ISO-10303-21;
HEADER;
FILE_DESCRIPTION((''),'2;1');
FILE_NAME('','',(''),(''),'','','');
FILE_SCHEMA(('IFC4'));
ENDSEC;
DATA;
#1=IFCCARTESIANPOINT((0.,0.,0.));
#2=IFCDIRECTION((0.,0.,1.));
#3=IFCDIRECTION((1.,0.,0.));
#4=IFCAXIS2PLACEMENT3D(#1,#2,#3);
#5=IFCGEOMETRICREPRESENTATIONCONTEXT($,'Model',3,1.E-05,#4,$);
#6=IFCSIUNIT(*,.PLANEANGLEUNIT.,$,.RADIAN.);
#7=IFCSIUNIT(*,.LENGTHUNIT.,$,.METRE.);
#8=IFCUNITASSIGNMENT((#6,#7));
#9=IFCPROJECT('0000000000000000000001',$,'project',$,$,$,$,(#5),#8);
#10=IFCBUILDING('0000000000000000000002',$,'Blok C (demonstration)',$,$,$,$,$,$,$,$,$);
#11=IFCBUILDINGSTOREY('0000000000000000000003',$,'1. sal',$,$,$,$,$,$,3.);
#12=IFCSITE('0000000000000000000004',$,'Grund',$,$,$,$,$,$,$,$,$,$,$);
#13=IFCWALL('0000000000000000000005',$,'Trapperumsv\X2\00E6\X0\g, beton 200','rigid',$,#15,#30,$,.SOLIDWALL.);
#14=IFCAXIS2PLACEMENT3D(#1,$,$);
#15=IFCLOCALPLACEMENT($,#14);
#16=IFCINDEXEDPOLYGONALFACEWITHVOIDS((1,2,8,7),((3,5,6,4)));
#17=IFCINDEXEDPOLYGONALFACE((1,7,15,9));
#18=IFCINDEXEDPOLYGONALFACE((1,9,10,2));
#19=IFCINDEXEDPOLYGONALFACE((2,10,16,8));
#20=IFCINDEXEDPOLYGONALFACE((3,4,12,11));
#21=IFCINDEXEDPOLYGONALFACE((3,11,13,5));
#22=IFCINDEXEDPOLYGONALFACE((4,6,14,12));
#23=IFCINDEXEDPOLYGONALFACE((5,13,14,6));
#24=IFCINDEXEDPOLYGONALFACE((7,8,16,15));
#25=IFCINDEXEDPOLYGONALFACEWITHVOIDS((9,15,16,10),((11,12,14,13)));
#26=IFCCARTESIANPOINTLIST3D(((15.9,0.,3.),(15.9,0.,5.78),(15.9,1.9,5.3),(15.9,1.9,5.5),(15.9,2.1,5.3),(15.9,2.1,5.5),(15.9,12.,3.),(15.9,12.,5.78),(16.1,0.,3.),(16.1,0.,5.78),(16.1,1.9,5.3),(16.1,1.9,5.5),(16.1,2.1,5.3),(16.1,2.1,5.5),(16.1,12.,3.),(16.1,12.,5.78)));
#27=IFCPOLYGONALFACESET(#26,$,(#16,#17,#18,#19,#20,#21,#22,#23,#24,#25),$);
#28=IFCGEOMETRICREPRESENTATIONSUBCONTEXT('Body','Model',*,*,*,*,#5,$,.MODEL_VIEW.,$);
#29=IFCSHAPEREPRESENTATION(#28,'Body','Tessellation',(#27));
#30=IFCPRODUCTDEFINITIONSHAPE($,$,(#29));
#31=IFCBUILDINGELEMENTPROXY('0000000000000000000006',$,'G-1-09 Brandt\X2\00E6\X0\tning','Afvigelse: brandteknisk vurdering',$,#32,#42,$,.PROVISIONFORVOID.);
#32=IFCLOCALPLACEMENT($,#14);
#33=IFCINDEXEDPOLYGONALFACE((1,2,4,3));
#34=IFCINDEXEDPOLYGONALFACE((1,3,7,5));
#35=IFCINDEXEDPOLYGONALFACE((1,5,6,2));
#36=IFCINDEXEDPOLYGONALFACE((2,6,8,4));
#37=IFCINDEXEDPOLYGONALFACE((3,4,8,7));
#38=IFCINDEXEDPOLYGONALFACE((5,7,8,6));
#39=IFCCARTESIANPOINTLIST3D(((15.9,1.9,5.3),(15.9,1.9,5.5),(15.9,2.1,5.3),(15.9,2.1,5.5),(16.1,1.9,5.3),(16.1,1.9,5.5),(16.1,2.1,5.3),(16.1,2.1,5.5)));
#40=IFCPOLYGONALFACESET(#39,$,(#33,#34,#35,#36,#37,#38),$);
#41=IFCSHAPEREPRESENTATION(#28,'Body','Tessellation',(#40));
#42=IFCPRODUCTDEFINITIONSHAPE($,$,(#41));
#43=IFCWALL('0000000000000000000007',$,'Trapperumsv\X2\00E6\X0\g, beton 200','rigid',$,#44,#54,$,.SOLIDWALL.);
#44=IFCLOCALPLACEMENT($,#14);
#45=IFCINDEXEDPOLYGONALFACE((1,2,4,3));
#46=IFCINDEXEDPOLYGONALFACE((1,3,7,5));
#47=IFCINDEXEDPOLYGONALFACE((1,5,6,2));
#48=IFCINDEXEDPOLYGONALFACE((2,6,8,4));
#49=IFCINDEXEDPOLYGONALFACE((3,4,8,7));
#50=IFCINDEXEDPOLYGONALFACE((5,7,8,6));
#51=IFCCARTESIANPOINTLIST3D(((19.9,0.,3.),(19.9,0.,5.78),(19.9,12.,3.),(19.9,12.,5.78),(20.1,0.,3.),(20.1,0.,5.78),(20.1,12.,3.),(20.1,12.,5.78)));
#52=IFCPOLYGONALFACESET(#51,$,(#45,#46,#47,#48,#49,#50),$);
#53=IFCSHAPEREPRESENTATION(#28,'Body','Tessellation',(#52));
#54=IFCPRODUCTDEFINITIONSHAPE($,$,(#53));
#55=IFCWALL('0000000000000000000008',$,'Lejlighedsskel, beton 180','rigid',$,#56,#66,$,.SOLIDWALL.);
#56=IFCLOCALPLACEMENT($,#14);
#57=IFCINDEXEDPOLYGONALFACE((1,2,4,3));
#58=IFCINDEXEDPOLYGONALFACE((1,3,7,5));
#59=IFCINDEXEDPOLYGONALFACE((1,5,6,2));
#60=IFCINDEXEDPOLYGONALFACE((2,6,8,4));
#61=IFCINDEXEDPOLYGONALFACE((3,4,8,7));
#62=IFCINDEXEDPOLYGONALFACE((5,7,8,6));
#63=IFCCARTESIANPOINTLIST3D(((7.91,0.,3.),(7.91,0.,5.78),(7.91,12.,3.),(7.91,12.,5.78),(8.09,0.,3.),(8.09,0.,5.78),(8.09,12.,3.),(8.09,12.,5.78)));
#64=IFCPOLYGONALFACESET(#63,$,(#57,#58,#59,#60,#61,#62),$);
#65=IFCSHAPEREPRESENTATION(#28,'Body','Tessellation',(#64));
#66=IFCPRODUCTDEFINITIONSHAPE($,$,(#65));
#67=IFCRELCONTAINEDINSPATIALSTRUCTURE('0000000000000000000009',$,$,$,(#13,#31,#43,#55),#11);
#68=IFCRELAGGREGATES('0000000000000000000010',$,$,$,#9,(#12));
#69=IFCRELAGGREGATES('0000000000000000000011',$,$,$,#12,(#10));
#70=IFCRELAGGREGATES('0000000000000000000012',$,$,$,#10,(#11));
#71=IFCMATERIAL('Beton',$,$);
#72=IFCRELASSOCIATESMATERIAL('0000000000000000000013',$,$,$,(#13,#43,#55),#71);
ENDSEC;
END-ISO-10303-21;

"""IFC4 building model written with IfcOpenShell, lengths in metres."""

from ifc_helpers import new_model, si_unit, frame, origin_with_axes, place, context, subcontext, project, spatial, polyline, outline, extrude, material, element, fill, save


model = new_model("IFC4")

# Units and contexts
model_context = context("Model", 3, precision=1e-05, world=origin_with_axes())
body_context = subcontext(model_context, "Body", "Model", "MODEL_VIEW")
ifc_project = project(units=[si_unit("PLANEANGLEUNIT", "RADIAN"), si_unit("LENGTHUNIT", "METRE")], contexts=[model_context])

# Site, building, storey
site = spatial("IfcSite", under=ifc_project, Name="Grund")
building = spatial("IfcBuilding", under=site, Name="Blok C (demonstration)")
storey = spatial("IfcBuildingStorey", under=building, Name="1. sal", Elevation=3.0)

# Wall, opening, building element proxy
ifc_material_1 = material(Name="Beton")
wall_1_placement = place(None, origin_with_axes())
wall_1 = element("IfcWall", 1, at=wall_1_placement, inside=storey, material=ifc_material_1, Name="Trapperumsvæg, beton 200", Description="rigid", PredefinedType="SOLIDWALL", context=body_context, shape_type="SweptSolid", body=[
    extrude(outline(polyline([(15.9, 0.0), (16.1, 0.0), (16.1, 12.0), (15.9, 12.0), (15.9, 0.0)])), frame((0.0, 0.0, 3.0)), (0.0, 0.0, 1.0), 2.78),
])
opening_1_placement = place(wall_1_placement, origin_with_axes())
opening_1 = element("IfcOpeningElement", 2, at=opening_1_placement, cuts=wall_1, PredefinedType="OPENING", context=body_context, shape_type="SweptSolid", body=[
    extrude(outline(polyline([(15.88, 1.9), (16.12, 1.9), (16.12, 2.1), (15.88, 2.1), (15.88, 1.9)])), frame((0.0, 0.0, 5.3)), (0.0, 0.0, 1.0), 0.2),
])
proxy_1_placement = place(None, origin_with_axes())
proxy_1 = element("IfcBuildingElementProxy", 3, at=proxy_1_placement, inside=storey, Name="G-1-09 Brandtætning", Description="Afvigelse: brandteknisk vurdering", PredefinedType="PROVISIONFORVOID", context=body_context, shape_type="SweptSolid", body=[
    extrude(outline(polyline([(15.9, 1.9), (16.1, 1.9), (16.1, 2.1), (15.9, 2.1), (15.9, 1.9)])), frame((0.0, 0.0, 5.3)), (0.0, 0.0, 1.0), 0.2),
])
fill(opening_1, proxy_1)

# Walls
wall_2_placement = place(None, origin_with_axes())
element("IfcWall", 4, at=wall_2_placement, inside=storey, material=ifc_material_1, Name="Trapperumsvæg, beton 200", Description="rigid", PredefinedType="SOLIDWALL", context=body_context, shape_type="SweptSolid", body=[
    extrude(outline(polyline([(19.9, 0.0), (20.1, 0.0), (20.1, 12.0), (19.9, 12.0), (19.9, 0.0)])), frame((0.0, 0.0, 3.0)), (0.0, 0.0, 1.0), 2.78),
])
wall_3_placement = place(None, origin_with_axes())
element("IfcWall", 5, at=wall_3_placement, inside=storey, material=ifc_material_1, Name="Lejlighedsskel, beton 180", Description="rigid", PredefinedType="SOLIDWALL", context=body_context, shape_type="SweptSolid", body=[
    extrude(outline(polyline([(7.91, 0.0), (8.09, 0.0), (8.09, 12.0), (7.91, 12.0), (7.91, 0.0)])), frame((0.0, 0.0, 3.0)), (0.0, 0.0, 1.0), 2.78),
])

save(model, "model.ifc")
